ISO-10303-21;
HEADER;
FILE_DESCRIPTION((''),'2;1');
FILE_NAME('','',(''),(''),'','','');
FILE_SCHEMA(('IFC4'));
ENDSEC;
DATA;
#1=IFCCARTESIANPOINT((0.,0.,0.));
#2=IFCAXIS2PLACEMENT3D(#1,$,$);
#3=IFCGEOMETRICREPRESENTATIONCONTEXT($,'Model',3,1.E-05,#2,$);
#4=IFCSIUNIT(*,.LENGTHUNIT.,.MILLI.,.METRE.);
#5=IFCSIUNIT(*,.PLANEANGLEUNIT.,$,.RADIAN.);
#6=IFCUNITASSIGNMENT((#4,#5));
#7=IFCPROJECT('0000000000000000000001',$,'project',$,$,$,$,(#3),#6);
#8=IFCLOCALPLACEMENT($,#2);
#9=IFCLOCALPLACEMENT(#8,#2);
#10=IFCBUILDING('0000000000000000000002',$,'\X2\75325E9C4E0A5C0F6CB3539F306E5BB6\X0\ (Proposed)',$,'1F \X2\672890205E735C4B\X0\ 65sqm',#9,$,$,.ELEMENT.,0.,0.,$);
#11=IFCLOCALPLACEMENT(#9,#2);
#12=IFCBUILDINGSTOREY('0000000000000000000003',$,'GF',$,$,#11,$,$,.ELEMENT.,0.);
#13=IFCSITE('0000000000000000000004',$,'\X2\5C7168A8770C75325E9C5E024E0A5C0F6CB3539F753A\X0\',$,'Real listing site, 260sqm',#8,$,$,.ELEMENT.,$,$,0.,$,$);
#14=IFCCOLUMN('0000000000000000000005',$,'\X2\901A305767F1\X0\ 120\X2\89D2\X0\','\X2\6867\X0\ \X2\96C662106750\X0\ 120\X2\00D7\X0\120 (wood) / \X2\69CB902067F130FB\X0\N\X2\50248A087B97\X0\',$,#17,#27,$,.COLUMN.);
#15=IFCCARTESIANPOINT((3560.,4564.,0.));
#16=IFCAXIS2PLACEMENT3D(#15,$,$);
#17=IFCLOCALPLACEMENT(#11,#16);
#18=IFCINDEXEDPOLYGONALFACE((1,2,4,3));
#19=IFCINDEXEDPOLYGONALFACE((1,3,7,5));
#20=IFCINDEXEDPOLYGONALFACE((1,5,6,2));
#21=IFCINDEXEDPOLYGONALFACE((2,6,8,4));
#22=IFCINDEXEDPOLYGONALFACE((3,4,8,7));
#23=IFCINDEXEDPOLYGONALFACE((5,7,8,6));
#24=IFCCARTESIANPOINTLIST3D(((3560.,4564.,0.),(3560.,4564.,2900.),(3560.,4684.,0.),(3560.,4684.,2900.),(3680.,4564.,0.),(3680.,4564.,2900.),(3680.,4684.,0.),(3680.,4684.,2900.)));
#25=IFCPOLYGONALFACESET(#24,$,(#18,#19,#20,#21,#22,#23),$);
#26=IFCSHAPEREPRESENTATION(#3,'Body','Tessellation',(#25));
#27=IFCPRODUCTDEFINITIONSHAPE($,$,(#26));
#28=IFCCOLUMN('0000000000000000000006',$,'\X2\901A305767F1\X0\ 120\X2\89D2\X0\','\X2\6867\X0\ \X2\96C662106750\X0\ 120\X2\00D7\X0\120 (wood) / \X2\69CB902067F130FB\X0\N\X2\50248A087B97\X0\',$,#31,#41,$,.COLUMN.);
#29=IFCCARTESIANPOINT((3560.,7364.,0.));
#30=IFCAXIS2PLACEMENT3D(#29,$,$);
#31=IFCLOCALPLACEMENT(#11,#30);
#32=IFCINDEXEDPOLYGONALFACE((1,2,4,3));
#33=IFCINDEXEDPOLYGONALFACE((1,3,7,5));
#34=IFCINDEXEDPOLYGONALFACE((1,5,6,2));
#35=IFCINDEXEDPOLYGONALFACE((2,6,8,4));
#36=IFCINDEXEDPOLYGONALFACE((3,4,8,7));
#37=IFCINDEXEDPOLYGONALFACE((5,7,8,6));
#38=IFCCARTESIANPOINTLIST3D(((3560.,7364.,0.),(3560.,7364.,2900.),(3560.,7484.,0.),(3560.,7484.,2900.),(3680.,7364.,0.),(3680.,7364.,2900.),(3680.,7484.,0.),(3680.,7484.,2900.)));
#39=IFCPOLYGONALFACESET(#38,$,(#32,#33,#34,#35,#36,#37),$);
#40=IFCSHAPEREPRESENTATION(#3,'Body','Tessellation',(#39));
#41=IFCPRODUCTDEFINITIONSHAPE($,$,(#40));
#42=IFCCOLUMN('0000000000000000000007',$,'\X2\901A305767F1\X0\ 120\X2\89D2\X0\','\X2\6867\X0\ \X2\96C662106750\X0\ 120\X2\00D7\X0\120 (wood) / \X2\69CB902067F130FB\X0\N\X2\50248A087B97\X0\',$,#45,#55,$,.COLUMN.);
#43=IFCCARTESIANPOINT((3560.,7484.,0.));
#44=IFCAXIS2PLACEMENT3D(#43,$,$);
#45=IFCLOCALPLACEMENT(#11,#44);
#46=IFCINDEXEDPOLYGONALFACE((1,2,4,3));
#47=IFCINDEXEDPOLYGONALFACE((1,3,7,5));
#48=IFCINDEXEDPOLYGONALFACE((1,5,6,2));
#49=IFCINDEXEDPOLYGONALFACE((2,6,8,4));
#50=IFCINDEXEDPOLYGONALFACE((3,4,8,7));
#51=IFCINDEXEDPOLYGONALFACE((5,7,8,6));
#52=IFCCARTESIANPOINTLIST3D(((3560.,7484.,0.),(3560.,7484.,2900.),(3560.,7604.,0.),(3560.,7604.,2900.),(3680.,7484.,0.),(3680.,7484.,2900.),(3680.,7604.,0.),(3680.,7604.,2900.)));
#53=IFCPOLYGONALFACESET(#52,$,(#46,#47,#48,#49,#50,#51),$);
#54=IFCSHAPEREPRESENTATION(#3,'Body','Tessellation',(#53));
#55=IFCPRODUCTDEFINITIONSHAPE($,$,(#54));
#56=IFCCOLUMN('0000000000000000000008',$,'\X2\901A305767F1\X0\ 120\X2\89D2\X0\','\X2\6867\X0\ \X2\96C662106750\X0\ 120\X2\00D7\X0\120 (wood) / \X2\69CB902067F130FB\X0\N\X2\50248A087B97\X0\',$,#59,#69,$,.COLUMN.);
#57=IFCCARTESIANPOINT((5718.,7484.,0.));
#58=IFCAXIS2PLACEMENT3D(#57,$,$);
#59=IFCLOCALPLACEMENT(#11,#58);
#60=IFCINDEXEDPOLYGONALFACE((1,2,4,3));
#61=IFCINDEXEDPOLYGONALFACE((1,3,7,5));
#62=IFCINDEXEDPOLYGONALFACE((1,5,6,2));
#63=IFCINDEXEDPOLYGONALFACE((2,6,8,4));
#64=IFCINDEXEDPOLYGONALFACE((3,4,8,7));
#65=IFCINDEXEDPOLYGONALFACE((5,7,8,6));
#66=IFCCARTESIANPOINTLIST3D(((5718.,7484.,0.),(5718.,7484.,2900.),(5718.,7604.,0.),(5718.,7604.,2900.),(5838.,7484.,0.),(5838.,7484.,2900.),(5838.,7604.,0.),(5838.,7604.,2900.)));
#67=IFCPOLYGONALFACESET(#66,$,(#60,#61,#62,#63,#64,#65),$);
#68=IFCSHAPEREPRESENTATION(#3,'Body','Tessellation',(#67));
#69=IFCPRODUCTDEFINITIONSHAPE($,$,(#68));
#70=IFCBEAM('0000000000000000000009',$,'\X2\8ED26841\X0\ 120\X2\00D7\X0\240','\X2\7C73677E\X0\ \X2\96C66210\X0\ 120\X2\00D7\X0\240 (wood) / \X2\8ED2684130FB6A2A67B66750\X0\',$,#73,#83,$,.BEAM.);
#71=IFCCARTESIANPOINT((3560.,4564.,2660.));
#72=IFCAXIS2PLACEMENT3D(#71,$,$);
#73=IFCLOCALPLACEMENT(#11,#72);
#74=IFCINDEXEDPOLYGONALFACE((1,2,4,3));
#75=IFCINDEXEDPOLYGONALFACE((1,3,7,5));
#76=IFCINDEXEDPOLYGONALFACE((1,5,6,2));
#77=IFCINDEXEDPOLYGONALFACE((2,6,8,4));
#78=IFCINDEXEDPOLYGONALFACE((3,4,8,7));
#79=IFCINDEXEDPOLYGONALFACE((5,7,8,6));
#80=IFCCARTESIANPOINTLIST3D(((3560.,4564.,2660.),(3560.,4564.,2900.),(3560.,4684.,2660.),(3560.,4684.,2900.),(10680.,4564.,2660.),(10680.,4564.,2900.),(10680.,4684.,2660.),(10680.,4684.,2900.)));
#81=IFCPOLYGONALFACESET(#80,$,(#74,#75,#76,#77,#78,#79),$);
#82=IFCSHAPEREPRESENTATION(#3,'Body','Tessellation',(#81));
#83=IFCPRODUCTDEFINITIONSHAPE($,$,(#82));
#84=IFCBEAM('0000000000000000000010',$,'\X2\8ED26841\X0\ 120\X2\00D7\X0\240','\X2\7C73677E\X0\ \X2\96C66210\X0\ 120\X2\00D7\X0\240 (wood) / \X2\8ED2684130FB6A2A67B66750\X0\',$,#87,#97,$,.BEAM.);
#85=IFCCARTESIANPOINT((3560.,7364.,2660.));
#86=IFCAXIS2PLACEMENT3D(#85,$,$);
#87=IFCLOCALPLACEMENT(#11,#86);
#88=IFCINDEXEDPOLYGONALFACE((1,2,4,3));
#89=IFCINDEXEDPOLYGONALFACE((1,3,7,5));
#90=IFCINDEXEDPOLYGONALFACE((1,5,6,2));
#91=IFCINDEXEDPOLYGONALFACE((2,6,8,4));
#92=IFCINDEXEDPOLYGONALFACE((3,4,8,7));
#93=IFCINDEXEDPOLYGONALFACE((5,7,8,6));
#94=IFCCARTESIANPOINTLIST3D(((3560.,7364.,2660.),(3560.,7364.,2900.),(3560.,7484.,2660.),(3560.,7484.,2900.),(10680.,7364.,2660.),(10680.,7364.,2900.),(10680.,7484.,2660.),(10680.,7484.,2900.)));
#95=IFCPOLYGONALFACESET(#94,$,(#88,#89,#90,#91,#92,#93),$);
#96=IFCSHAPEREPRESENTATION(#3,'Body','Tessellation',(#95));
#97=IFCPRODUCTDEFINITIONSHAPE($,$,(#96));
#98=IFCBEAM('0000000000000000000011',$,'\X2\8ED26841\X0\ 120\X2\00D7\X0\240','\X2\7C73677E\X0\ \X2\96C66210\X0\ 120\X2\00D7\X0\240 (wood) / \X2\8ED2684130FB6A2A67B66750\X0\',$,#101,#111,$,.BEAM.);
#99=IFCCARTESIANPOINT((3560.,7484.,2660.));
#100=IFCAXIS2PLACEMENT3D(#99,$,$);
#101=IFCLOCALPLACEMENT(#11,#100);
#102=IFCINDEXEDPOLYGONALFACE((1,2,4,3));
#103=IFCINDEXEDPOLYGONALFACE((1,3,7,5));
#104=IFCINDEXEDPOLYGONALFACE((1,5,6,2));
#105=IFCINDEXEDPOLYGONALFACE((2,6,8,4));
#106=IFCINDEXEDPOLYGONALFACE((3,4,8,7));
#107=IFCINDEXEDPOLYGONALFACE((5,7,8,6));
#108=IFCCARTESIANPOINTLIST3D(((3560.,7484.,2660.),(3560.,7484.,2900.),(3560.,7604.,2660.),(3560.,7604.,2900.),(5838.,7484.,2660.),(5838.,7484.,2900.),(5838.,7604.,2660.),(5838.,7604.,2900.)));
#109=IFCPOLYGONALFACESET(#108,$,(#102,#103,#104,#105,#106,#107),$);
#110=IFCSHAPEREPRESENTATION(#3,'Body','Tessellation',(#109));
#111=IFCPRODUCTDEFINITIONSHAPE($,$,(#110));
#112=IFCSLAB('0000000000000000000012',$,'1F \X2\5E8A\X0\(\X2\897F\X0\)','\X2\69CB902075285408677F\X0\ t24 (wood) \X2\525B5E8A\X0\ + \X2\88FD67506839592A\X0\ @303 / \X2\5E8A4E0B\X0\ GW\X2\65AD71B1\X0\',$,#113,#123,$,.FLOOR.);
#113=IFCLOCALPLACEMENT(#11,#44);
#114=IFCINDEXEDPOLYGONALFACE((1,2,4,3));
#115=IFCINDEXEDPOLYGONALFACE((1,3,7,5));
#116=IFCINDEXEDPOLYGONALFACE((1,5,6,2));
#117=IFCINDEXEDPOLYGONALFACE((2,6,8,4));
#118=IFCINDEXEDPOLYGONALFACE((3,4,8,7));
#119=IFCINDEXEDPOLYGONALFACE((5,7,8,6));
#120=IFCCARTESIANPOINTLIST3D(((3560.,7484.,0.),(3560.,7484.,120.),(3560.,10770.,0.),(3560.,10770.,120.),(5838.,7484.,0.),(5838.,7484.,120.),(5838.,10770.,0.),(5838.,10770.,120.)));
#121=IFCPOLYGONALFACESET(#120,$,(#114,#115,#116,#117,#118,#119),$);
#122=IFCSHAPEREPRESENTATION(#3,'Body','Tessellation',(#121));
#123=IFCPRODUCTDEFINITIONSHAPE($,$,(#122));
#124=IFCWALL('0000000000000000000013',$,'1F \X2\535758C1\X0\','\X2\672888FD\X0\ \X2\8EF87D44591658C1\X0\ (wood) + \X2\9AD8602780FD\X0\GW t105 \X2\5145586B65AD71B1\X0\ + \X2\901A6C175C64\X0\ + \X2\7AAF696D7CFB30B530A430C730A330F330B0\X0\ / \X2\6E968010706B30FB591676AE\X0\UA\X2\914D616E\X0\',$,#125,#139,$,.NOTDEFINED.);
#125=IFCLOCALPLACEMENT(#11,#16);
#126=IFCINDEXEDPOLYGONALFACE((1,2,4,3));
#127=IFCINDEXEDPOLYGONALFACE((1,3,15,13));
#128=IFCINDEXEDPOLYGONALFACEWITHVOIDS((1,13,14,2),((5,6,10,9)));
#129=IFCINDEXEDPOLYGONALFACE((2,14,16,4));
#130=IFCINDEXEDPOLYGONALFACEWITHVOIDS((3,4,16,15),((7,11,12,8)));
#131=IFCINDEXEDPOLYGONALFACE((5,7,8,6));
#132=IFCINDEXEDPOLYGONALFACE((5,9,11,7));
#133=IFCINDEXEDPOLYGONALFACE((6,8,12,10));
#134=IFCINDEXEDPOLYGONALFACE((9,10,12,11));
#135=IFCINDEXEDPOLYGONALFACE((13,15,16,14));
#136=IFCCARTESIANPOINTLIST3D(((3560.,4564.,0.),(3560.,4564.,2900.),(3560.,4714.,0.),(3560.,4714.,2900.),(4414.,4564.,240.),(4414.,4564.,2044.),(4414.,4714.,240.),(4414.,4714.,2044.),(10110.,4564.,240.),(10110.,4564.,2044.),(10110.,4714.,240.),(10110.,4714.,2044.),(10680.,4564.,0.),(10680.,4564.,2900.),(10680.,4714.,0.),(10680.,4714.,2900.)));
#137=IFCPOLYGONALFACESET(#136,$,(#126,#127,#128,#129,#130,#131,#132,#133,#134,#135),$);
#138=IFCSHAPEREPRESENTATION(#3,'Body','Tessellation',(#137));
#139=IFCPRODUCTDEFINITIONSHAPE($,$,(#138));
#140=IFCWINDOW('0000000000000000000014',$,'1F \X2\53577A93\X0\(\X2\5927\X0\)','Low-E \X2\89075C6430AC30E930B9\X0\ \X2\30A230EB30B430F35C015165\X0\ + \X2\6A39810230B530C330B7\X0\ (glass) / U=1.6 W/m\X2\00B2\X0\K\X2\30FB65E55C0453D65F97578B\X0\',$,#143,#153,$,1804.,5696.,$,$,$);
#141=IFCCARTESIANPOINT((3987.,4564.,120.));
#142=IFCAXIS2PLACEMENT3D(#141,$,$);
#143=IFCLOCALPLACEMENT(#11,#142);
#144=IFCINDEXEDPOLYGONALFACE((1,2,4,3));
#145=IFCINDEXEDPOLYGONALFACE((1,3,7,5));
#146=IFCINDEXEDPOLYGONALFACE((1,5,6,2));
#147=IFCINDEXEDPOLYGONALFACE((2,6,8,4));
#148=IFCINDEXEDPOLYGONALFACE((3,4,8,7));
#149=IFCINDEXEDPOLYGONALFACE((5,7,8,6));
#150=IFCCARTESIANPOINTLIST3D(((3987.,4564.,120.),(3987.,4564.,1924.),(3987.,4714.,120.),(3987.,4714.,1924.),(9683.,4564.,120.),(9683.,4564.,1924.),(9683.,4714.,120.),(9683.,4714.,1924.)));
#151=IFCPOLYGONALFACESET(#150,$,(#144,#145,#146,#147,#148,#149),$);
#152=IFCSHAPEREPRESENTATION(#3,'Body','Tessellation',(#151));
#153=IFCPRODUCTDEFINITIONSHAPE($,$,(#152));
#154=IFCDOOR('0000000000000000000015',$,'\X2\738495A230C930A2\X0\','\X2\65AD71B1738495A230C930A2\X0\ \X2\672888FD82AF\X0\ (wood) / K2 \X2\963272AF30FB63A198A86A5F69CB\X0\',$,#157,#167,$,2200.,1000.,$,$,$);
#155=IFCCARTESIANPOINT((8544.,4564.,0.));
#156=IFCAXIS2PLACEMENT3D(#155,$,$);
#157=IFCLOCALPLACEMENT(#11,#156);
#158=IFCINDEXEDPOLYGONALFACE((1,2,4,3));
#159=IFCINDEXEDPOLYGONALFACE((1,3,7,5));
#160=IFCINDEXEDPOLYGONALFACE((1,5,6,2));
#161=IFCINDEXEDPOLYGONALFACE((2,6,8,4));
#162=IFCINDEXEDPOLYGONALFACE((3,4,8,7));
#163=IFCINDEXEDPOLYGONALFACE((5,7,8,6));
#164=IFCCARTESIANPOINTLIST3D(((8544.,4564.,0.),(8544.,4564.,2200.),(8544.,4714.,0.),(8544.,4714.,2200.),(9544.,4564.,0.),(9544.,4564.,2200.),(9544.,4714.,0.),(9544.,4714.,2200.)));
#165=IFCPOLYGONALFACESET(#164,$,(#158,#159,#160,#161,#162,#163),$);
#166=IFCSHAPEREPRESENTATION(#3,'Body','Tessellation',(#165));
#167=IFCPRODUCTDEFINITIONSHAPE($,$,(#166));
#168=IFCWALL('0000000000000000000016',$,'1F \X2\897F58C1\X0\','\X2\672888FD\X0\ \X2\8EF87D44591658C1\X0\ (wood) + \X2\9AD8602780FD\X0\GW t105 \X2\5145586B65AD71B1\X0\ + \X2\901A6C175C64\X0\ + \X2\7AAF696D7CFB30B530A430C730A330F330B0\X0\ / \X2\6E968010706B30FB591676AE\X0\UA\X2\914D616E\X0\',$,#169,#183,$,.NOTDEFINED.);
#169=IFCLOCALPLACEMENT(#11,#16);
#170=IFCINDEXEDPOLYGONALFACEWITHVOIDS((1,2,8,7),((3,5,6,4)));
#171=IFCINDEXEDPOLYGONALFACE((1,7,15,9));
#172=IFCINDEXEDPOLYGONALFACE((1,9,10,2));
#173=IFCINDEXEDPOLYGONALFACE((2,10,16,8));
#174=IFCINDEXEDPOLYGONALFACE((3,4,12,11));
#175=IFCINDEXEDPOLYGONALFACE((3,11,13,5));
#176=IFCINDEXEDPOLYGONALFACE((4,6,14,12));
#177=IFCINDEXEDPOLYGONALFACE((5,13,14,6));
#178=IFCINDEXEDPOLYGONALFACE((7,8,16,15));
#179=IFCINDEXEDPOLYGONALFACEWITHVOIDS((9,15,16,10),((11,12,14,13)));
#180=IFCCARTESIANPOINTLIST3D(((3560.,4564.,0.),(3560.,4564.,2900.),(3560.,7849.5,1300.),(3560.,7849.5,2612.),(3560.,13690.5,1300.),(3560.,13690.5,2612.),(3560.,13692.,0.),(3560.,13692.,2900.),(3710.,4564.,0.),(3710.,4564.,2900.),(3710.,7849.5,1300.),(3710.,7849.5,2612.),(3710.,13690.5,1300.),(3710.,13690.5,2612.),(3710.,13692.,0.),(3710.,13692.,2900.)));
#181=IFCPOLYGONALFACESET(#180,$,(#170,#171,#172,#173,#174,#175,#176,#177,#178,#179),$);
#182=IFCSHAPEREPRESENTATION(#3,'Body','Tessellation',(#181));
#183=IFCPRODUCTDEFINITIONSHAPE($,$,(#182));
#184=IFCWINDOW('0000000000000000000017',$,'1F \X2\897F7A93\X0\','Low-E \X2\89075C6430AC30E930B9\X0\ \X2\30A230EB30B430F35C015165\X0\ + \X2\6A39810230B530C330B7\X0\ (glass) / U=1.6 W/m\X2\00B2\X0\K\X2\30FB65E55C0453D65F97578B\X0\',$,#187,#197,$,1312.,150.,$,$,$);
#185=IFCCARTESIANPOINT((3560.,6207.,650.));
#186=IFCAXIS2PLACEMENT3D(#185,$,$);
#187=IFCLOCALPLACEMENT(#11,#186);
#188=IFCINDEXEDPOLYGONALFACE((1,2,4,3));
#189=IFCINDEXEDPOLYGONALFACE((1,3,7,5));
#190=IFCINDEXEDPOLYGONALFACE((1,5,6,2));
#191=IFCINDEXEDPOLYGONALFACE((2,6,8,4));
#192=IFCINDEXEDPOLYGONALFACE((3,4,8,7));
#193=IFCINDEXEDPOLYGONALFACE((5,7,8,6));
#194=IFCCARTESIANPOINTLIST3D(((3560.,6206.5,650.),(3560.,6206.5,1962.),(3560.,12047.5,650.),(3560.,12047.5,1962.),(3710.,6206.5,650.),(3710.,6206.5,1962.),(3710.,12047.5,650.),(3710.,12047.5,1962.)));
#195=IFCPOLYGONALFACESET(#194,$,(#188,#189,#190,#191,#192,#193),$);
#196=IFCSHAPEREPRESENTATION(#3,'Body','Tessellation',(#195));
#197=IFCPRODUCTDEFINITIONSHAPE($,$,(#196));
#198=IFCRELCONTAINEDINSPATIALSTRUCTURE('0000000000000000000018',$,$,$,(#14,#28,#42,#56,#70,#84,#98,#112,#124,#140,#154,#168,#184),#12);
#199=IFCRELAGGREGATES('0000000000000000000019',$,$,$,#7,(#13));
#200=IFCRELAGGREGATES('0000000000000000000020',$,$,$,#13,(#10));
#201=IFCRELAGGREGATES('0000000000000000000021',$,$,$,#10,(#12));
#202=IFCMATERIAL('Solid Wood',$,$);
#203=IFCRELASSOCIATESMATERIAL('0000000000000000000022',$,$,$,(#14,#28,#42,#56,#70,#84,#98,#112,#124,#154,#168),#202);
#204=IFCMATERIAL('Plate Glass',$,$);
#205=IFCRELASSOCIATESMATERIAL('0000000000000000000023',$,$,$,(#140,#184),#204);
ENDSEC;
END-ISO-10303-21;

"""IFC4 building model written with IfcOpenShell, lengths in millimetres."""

from ifc_helpers import new_model, si_unit, frame, frame_2d, origin, place, context, project, spatial, rectangle, extrude, material, element, fill, save


model = new_model("IFC4")

# Units and contexts
model_context = context("Model", 3, precision=1e-05, world=origin())
ifc_project = project(units=[si_unit("LENGTHUNIT", "METRE", prefix="MILLI"), si_unit("PLANEANGLEUNIT", "RADIAN")], contexts=[model_context])

# Site, building, storey
site_placement = place(None, origin())
site = spatial("IfcSite", under=ifc_project, at=site_placement, Name="山梨県甲府市上小河原町", ObjectType="Real listing site, 260sqm", CompositionType="ELEMENT", RefElevation=0.0)
building_placement = place(site_placement, origin())
building = spatial("IfcBuilding", under=site, at=building_placement, Name="甲府上小河原の家 (Proposed)", ObjectType="1F 木造平屋 65sqm", CompositionType="ELEMENT", ElevationOfRefHeight=0.0, ElevationOfTerrain=0.0)
storey_placement = place(building_placement, origin())
storey = spatial("IfcBuildingStorey", under=building, at=storey_placement, Name="GF", CompositionType="ELEMENT", Elevation=0.0)

# Columns
ifc_material_1 = material(Name="Solid Wood")
column_1_placement = place(storey_placement, frame((3560.0, 4564.0, 0.0)))
element("IfcColumn", 1, at=column_1_placement, inside=storey, material=ifc_material_1, Name="通し柱 120角", Description="桧 集成材 120×120 (wood) / 構造柱・N値計算", PredefinedType="COLUMN", context=model_context, shape_type="SweptSolid", body=[
    extrude(rectangle(XDim=120.0, YDim=120.0, at=frame_2d((60.0, 60.0))), frame((3560.0, 4564.0, 0.0)), (0.0, 0.0, 1.0), 2900.0),
])
column_2_placement = place(storey_placement, frame((3560.0, 7364.0, 0.0)))
element("IfcColumn", 2, at=column_2_placement, inside=storey, material=ifc_material_1, Name="通し柱 120角", Description="桧 集成材 120×120 (wood) / 構造柱・N値計算", PredefinedType="COLUMN", context=model_context, shape_type="SweptSolid", body=[
    extrude(rectangle(XDim=120.0, YDim=120.0, at=frame_2d((60.0, 60.0))), frame((3560.0, 7364.0, 0.0)), (0.0, 0.0, 1.0), 2900.0),
])
column_3_placement = place(storey_placement, frame((3560.0, 7484.0, 0.0)))
element("IfcColumn", 3, at=column_3_placement, inside=storey, material=ifc_material_1, Name="通し柱 120角", Description="桧 集成材 120×120 (wood) / 構造柱・N値計算", PredefinedType="COLUMN", context=model_context, shape_type="SweptSolid", body=[
    extrude(rectangle(XDim=120.0, YDim=120.0, at=frame_2d((60.0, 60.0))), frame((3560.0, 7484.0, 0.0)), (0.0, 0.0, 1.0), 2900.0),
])
column_4_placement = place(storey_placement, frame((5718.0, 7484.0, 0.0)))
element("IfcColumn", 4, at=column_4_placement, inside=storey, material=ifc_material_1, Name="通し柱 120角", Description="桧 集成材 120×120 (wood) / 構造柱・N値計算", PredefinedType="COLUMN", context=model_context, shape_type="SweptSolid", body=[
    extrude(rectangle(XDim=120.0, YDim=120.0, at=frame_2d((60.0, 60.0))), frame((5718.0, 7484.0, 0.0)), (0.0, 0.0, 1.0), 2900.0),
])

# Beams
beam_1_placement = place(storey_placement, frame((3560.0, 4564.0, 2660.0)))
element("IfcBeam", 5, at=beam_1_placement, inside=storey, material=ifc_material_1, Name="軒桁 120×240", Description="米松 集成 120×240 (wood) / 軒桁・横架材", PredefinedType="BEAM", context=model_context, shape_type="SweptSolid", body=[
    extrude(rectangle(XDim=7120.0, YDim=120.0, at=frame_2d((3560.0, 60.0))), frame((3560.0, 4564.0, 2660.0)), (0.0, 0.0, 1.0), 240.0),
])
beam_2_placement = place(storey_placement, frame((3560.0, 7364.0, 2660.0)))
element("IfcBeam", 6, at=beam_2_placement, inside=storey, material=ifc_material_1, Name="軒桁 120×240", Description="米松 集成 120×240 (wood) / 軒桁・横架材", PredefinedType="BEAM", context=model_context, shape_type="SweptSolid", body=[
    extrude(rectangle(XDim=7120.0, YDim=120.0, at=frame_2d((3560.0, 60.0))), frame((3560.0, 7364.0, 2660.0)), (0.0, 0.0, 1.0), 240.0),
])
beam_3_placement = place(storey_placement, frame((3560.0, 7484.0, 2660.0)))
element("IfcBeam", 7, at=beam_3_placement, inside=storey, material=ifc_material_1, Name="軒桁 120×240", Description="米松 集成 120×240 (wood) / 軒桁・横架材", PredefinedType="BEAM", context=model_context, shape_type="SweptSolid", body=[
    extrude(rectangle(XDim=2278.0, YDim=120.0, at=frame_2d((1139.0, 60.0))), frame((3560.0, 7484.0, 2660.0)), (0.0, 0.0, 1.0), 240.0),
])

# Slab
slab_1_placement = place(storey_placement, frame((3560.0, 7484.0, 0.0)))
element("IfcSlab", 8, at=slab_1_placement, inside=storey, material=ifc_material_1, Name="1F 床(西)", Description="構造用合板 t24 (wood) 剛床 + 製材根太 @303 / 床下 GW断熱", PredefinedType="FLOOR", context=model_context, shape_type="SweptSolid", body=[
    extrude(rectangle(XDim=2278.0, YDim=3286.0, at=frame_2d((1139.0, 1643.0))), frame((3560.0, 7484.0, 0.0)), (0.0, 0.0, 1.0), 120.0),
])

# Wall, openings, window, door
wall_1_placement = place(storey_placement, frame((3560.0, 4564.0, 0.0)))
wall_1 = element("IfcWall", 9, at=wall_1_placement, inside=storey, material=ifc_material_1, Name="1F 南壁", Description="木製 軸組外壁 (wood) + 高性能GW t105 充填断熱 + 通気層 + 窯業系サイディング / 準耐火・外皮UA配慮", PredefinedType="NOTDEFINED", context=model_context, shape_type="SweptSolid", body=[
    extrude(rectangle(XDim=7120.0, YDim=150.0, at=frame_2d((3560.0, 75.0))), frame((3560.0, 4564.0, 0.0)), (0.0, 0.0, 1.0), 2900.0),
])
opening_1_placement = place(storey_placement, frame((3987.0, 4564.0, 120.0)))
opening_1 = element("IfcOpeningElement", 10, at=opening_1_placement, cuts=wall_1, PredefinedType="NOTDEFINED", context=model_context, shape_type="SweptSolid", body=[
    extrude(rectangle(XDim=5696.0, YDim=150.0, at=frame_2d((2848.0, 75.0))), frame((3987.0, 4564.0, 120.0)), (0.0, 0.0, 1.0), 1804.0),
])
opening_2_placement = place(storey_placement, frame((8544.0, 4564.0, 0.0)))
opening_2 = element("IfcOpeningElement", 11, at=opening_2_placement, cuts=wall_1, PredefinedType="NOTDEFINED", context=model_context, shape_type="SweptSolid", body=[
    extrude(rectangle(XDim=1000.0, YDim=150.0, at=frame_2d((500.0, 75.0))), frame((8544.0, 4564.0, 0.0)), (0.0, 0.0, 1.0), 2200.0),
])
ifc_material_2 = material(Name="Plate Glass")
window_1_placement = place(storey_placement, frame((3987.0, 4564.0, 120.0)))
window_1 = element("IfcWindow", 12, at=window_1_placement, inside=storey, material=ifc_material_2, Name="1F 南窓(大)", Description="Low-E 複層ガラス アルゴン封入 + 樹脂サッシ (glass) / U=1.6 W/m²K・日射取得型", OverallHeight=1804.0, OverallWidth=5696.0, context=model_context, shape_type="SweptSolid", body=[
    extrude(rectangle(XDim=5696.0, YDim=150.0, at=frame_2d((2848.0, 75.0))), frame((3987.0, 4564.0, 120.0)), (0.0, 0.0, 1.0), 1804.0),
])
fill(opening_1, window_1)
door_placement = place(storey_placement, frame((8544.0, 4564.0, 0.0)))
door = element("IfcDoor", 13, at=door_placement, inside=storey, material=ifc_material_1, Name="玄関ドア", Description="断熱玄関ドア 木製芯 (wood) / K2 防犯・採風機構", OverallHeight=2200.0, OverallWidth=1000.0, context=model_context, shape_type="SweptSolid", body=[
    extrude(rectangle(XDim=1000.0, YDim=150.0, at=frame_2d((500.0, 75.0))), frame((8544.0, 4564.0, 0.0)), (0.0, 0.0, 1.0), 2200.0),
])
fill(opening_2, door)

# Wall, opening, window
wall_2_placement = place(storey_placement, frame((3560.0, 4564.0, 0.0)))
wall_2 = element("IfcWall", 14, at=wall_2_placement, inside=storey, material=ifc_material_1, Name="1F 西壁", Description="木製 軸組外壁 (wood) + 高性能GW t105 充填断熱 + 通気層 + 窯業系サイディング / 準耐火・外皮UA配慮", PredefinedType="NOTDEFINED", context=model_context, shape_type="SweptSolid", body=[
    extrude(rectangle(XDim=150.0, YDim=9128.0, at=frame_2d((75.0, 4564.0))), frame((3560.0, 4564.0, 0.0)), (0.0, 0.0, 1.0), 2900.0),
])
opening_3_placement = place(storey_placement, frame((3560.0, 6207.0, 650.0)))
opening_3 = element("IfcOpeningElement", 15, at=opening_3_placement, cuts=wall_2, PredefinedType="NOTDEFINED", context=model_context, shape_type="SweptSolid", body=[
    extrude(rectangle(XDim=150.0, YDim=5841.0, at=frame_2d((75.0, 2920.0))), frame((3560.0, 6207.0, 650.0)), (0.0, 0.0, 1.0), 1312.0),
])
window_2_placement = place(storey_placement, frame((3560.0, 6207.0, 650.0)))
window_2 = element("IfcWindow", 16, at=window_2_placement, inside=storey, material=ifc_material_2, Name="1F 西窓", Description="Low-E 複層ガラス アルゴン封入 + 樹脂サッシ (glass) / U=1.6 W/m²K・日射取得型", OverallHeight=1312.0, OverallWidth=150.0, context=model_context, shape_type="SweptSolid", body=[
    extrude(rectangle(XDim=150.0, YDim=5841.0, at=frame_2d((75.0, 2920.0))), frame((3560.0, 6207.0, 650.0)), (0.0, 0.0, 1.0), 1312.0),
])
fill(opening_3, window_2)

save(model, "model.ifc")
